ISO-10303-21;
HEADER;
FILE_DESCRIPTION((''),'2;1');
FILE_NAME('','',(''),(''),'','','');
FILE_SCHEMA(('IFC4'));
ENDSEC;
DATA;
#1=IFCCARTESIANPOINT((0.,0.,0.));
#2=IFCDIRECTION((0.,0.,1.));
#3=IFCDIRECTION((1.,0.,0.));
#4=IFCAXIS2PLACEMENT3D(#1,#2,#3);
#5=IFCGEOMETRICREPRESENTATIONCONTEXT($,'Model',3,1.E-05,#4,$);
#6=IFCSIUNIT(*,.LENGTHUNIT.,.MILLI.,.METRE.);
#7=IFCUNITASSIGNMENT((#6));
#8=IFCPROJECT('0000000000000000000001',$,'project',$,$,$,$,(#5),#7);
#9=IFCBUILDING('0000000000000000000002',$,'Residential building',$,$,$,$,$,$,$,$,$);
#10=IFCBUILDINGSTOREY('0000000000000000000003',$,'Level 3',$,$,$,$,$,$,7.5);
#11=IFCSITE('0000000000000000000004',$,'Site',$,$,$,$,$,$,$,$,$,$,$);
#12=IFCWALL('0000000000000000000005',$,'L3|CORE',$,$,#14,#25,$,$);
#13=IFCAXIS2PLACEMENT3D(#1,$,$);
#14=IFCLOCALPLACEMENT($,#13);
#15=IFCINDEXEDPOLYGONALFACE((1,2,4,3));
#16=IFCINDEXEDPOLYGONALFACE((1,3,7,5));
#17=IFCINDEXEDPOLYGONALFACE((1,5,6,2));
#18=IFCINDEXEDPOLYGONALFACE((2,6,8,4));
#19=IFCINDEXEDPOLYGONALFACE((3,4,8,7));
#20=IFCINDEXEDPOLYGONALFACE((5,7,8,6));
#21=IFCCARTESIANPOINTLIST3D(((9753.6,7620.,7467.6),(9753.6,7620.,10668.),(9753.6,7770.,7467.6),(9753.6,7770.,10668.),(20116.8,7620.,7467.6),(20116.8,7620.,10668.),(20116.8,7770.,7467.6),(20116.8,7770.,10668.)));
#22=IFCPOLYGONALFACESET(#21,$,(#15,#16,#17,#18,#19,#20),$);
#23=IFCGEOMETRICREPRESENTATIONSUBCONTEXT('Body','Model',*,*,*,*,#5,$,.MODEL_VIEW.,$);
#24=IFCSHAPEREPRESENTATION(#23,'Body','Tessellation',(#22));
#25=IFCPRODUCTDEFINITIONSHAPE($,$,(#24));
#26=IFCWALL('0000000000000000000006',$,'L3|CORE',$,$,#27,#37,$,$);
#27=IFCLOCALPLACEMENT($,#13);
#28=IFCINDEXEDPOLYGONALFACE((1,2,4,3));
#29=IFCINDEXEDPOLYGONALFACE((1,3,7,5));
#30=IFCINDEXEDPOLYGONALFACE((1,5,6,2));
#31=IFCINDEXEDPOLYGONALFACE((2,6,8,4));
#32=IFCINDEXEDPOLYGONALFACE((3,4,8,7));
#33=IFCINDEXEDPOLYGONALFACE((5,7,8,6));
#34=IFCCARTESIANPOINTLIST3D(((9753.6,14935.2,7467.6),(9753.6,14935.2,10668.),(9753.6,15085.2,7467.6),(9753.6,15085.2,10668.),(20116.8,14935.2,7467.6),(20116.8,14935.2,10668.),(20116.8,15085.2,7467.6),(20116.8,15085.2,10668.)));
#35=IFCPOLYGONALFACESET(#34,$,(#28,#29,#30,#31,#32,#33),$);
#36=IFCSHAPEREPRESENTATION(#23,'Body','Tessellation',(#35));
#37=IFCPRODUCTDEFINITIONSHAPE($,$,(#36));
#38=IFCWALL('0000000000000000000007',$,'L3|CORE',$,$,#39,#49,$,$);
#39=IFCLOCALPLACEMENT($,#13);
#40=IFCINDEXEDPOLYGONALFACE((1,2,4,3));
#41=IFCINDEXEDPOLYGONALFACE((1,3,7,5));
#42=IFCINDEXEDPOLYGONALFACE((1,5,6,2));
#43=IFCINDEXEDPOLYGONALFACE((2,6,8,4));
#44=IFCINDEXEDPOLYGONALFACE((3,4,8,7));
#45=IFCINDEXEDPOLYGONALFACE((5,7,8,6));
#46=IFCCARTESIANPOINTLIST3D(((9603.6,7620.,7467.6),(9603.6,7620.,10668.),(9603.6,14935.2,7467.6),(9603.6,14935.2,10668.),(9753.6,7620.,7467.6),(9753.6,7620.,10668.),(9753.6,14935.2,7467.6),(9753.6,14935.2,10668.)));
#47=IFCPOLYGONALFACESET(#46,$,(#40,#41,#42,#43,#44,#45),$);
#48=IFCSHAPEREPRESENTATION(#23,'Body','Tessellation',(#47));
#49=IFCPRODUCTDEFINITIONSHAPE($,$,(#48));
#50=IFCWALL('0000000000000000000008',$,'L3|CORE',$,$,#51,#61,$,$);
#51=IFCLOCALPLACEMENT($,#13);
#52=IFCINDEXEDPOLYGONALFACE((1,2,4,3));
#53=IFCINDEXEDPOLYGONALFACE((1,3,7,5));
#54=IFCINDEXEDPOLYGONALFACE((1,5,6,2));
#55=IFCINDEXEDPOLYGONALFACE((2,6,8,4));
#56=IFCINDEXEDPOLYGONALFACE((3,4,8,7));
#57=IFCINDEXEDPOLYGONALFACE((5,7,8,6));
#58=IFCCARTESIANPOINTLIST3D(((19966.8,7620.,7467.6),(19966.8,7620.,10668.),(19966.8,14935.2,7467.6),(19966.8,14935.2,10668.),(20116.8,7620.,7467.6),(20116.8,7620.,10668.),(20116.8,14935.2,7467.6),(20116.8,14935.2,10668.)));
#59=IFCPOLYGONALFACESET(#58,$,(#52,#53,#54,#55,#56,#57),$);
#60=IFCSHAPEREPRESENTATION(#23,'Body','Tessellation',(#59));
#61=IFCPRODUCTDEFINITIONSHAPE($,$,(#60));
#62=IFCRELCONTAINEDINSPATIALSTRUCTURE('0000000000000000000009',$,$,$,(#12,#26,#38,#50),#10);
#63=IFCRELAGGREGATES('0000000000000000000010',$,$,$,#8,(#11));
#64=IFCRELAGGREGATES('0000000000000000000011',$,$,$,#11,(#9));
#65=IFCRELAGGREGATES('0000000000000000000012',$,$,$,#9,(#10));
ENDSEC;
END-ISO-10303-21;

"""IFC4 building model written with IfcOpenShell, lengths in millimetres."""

from ifc_helpers import new_model, si_unit, frame, origin_with_axes, place, context, subcontext, project, spatial, indexed_curve, outline, extrude, element, save


model = new_model("IFC4")

# Units and contexts
model_context = context("Model", 3, precision=1e-05, world=origin_with_axes())
body_context = subcontext(model_context, "Body", "Model", "MODEL_VIEW")
ifc_project = project(units=[si_unit("LENGTHUNIT", "METRE", prefix="MILLI")], contexts=[model_context])

# Site, building, storey
site = spatial("IfcSite", under=ifc_project, Name="Site")
building = spatial("IfcBuilding", under=site, Name="Residential building")
storey = spatial("IfcBuildingStorey", under=building, Name="Level 3", Elevation=7.5)

# Walls
for number, where, z_axis, x_axis, name in (
    (1, (9753.6, 7620.0, 7467.6), (0.0, 0.0, 1.0), (1.0, 0.0, 0.0), "L3|CORE"),
    (2, (9753.6, 14935.2, 7467.6), (0.0, 0.0, 1.0), (1.0, 0.0, 0.0), "L3|CORE"),
):
    element("IfcWall", number, at=place(None, frame(where, z_axis=z_axis, x_axis=x_axis)), inside=storey, Name=name, context=body_context, shape_type="SweptSolid", body=[
        extrude(outline(indexed_curve([(0.0, 0.0), (0.0, 150.0), (10363.2, 150.0), (10363.2, 0.0), (0.0, 0.0)], self_intersect=False)), origin_with_axes(), (0.0, 0.0, 1.0), 3200.4),
    ])
for number, where, z_axis, x_axis, name in (
    (3, (9753.6, 7620.0, 7467.6), (0.0, 0.0, 1.0), (0.0, 1.0, 0.0), "L3|CORE"),
    (4, (20116.8, 7620.0, 7467.6), (0.0, 0.0, 1.0), (0.0, 1.0, 0.0), "L3|CORE"),
):
    element("IfcWall", number, at=place(None, frame(where, z_axis=z_axis, x_axis=x_axis)), inside=storey, Name=name, context=body_context, shape_type="SweptSolid", body=[
        extrude(outline(indexed_curve([(0.0, 0.0), (0.0, 150.0), (7315.2, 150.0), (7315.2, 0.0), (0.0, 0.0)], self_intersect=False)), origin_with_axes(), (0.0, 0.0, 1.0), 3200.4),
    ])

save(model, "model.ifc")
